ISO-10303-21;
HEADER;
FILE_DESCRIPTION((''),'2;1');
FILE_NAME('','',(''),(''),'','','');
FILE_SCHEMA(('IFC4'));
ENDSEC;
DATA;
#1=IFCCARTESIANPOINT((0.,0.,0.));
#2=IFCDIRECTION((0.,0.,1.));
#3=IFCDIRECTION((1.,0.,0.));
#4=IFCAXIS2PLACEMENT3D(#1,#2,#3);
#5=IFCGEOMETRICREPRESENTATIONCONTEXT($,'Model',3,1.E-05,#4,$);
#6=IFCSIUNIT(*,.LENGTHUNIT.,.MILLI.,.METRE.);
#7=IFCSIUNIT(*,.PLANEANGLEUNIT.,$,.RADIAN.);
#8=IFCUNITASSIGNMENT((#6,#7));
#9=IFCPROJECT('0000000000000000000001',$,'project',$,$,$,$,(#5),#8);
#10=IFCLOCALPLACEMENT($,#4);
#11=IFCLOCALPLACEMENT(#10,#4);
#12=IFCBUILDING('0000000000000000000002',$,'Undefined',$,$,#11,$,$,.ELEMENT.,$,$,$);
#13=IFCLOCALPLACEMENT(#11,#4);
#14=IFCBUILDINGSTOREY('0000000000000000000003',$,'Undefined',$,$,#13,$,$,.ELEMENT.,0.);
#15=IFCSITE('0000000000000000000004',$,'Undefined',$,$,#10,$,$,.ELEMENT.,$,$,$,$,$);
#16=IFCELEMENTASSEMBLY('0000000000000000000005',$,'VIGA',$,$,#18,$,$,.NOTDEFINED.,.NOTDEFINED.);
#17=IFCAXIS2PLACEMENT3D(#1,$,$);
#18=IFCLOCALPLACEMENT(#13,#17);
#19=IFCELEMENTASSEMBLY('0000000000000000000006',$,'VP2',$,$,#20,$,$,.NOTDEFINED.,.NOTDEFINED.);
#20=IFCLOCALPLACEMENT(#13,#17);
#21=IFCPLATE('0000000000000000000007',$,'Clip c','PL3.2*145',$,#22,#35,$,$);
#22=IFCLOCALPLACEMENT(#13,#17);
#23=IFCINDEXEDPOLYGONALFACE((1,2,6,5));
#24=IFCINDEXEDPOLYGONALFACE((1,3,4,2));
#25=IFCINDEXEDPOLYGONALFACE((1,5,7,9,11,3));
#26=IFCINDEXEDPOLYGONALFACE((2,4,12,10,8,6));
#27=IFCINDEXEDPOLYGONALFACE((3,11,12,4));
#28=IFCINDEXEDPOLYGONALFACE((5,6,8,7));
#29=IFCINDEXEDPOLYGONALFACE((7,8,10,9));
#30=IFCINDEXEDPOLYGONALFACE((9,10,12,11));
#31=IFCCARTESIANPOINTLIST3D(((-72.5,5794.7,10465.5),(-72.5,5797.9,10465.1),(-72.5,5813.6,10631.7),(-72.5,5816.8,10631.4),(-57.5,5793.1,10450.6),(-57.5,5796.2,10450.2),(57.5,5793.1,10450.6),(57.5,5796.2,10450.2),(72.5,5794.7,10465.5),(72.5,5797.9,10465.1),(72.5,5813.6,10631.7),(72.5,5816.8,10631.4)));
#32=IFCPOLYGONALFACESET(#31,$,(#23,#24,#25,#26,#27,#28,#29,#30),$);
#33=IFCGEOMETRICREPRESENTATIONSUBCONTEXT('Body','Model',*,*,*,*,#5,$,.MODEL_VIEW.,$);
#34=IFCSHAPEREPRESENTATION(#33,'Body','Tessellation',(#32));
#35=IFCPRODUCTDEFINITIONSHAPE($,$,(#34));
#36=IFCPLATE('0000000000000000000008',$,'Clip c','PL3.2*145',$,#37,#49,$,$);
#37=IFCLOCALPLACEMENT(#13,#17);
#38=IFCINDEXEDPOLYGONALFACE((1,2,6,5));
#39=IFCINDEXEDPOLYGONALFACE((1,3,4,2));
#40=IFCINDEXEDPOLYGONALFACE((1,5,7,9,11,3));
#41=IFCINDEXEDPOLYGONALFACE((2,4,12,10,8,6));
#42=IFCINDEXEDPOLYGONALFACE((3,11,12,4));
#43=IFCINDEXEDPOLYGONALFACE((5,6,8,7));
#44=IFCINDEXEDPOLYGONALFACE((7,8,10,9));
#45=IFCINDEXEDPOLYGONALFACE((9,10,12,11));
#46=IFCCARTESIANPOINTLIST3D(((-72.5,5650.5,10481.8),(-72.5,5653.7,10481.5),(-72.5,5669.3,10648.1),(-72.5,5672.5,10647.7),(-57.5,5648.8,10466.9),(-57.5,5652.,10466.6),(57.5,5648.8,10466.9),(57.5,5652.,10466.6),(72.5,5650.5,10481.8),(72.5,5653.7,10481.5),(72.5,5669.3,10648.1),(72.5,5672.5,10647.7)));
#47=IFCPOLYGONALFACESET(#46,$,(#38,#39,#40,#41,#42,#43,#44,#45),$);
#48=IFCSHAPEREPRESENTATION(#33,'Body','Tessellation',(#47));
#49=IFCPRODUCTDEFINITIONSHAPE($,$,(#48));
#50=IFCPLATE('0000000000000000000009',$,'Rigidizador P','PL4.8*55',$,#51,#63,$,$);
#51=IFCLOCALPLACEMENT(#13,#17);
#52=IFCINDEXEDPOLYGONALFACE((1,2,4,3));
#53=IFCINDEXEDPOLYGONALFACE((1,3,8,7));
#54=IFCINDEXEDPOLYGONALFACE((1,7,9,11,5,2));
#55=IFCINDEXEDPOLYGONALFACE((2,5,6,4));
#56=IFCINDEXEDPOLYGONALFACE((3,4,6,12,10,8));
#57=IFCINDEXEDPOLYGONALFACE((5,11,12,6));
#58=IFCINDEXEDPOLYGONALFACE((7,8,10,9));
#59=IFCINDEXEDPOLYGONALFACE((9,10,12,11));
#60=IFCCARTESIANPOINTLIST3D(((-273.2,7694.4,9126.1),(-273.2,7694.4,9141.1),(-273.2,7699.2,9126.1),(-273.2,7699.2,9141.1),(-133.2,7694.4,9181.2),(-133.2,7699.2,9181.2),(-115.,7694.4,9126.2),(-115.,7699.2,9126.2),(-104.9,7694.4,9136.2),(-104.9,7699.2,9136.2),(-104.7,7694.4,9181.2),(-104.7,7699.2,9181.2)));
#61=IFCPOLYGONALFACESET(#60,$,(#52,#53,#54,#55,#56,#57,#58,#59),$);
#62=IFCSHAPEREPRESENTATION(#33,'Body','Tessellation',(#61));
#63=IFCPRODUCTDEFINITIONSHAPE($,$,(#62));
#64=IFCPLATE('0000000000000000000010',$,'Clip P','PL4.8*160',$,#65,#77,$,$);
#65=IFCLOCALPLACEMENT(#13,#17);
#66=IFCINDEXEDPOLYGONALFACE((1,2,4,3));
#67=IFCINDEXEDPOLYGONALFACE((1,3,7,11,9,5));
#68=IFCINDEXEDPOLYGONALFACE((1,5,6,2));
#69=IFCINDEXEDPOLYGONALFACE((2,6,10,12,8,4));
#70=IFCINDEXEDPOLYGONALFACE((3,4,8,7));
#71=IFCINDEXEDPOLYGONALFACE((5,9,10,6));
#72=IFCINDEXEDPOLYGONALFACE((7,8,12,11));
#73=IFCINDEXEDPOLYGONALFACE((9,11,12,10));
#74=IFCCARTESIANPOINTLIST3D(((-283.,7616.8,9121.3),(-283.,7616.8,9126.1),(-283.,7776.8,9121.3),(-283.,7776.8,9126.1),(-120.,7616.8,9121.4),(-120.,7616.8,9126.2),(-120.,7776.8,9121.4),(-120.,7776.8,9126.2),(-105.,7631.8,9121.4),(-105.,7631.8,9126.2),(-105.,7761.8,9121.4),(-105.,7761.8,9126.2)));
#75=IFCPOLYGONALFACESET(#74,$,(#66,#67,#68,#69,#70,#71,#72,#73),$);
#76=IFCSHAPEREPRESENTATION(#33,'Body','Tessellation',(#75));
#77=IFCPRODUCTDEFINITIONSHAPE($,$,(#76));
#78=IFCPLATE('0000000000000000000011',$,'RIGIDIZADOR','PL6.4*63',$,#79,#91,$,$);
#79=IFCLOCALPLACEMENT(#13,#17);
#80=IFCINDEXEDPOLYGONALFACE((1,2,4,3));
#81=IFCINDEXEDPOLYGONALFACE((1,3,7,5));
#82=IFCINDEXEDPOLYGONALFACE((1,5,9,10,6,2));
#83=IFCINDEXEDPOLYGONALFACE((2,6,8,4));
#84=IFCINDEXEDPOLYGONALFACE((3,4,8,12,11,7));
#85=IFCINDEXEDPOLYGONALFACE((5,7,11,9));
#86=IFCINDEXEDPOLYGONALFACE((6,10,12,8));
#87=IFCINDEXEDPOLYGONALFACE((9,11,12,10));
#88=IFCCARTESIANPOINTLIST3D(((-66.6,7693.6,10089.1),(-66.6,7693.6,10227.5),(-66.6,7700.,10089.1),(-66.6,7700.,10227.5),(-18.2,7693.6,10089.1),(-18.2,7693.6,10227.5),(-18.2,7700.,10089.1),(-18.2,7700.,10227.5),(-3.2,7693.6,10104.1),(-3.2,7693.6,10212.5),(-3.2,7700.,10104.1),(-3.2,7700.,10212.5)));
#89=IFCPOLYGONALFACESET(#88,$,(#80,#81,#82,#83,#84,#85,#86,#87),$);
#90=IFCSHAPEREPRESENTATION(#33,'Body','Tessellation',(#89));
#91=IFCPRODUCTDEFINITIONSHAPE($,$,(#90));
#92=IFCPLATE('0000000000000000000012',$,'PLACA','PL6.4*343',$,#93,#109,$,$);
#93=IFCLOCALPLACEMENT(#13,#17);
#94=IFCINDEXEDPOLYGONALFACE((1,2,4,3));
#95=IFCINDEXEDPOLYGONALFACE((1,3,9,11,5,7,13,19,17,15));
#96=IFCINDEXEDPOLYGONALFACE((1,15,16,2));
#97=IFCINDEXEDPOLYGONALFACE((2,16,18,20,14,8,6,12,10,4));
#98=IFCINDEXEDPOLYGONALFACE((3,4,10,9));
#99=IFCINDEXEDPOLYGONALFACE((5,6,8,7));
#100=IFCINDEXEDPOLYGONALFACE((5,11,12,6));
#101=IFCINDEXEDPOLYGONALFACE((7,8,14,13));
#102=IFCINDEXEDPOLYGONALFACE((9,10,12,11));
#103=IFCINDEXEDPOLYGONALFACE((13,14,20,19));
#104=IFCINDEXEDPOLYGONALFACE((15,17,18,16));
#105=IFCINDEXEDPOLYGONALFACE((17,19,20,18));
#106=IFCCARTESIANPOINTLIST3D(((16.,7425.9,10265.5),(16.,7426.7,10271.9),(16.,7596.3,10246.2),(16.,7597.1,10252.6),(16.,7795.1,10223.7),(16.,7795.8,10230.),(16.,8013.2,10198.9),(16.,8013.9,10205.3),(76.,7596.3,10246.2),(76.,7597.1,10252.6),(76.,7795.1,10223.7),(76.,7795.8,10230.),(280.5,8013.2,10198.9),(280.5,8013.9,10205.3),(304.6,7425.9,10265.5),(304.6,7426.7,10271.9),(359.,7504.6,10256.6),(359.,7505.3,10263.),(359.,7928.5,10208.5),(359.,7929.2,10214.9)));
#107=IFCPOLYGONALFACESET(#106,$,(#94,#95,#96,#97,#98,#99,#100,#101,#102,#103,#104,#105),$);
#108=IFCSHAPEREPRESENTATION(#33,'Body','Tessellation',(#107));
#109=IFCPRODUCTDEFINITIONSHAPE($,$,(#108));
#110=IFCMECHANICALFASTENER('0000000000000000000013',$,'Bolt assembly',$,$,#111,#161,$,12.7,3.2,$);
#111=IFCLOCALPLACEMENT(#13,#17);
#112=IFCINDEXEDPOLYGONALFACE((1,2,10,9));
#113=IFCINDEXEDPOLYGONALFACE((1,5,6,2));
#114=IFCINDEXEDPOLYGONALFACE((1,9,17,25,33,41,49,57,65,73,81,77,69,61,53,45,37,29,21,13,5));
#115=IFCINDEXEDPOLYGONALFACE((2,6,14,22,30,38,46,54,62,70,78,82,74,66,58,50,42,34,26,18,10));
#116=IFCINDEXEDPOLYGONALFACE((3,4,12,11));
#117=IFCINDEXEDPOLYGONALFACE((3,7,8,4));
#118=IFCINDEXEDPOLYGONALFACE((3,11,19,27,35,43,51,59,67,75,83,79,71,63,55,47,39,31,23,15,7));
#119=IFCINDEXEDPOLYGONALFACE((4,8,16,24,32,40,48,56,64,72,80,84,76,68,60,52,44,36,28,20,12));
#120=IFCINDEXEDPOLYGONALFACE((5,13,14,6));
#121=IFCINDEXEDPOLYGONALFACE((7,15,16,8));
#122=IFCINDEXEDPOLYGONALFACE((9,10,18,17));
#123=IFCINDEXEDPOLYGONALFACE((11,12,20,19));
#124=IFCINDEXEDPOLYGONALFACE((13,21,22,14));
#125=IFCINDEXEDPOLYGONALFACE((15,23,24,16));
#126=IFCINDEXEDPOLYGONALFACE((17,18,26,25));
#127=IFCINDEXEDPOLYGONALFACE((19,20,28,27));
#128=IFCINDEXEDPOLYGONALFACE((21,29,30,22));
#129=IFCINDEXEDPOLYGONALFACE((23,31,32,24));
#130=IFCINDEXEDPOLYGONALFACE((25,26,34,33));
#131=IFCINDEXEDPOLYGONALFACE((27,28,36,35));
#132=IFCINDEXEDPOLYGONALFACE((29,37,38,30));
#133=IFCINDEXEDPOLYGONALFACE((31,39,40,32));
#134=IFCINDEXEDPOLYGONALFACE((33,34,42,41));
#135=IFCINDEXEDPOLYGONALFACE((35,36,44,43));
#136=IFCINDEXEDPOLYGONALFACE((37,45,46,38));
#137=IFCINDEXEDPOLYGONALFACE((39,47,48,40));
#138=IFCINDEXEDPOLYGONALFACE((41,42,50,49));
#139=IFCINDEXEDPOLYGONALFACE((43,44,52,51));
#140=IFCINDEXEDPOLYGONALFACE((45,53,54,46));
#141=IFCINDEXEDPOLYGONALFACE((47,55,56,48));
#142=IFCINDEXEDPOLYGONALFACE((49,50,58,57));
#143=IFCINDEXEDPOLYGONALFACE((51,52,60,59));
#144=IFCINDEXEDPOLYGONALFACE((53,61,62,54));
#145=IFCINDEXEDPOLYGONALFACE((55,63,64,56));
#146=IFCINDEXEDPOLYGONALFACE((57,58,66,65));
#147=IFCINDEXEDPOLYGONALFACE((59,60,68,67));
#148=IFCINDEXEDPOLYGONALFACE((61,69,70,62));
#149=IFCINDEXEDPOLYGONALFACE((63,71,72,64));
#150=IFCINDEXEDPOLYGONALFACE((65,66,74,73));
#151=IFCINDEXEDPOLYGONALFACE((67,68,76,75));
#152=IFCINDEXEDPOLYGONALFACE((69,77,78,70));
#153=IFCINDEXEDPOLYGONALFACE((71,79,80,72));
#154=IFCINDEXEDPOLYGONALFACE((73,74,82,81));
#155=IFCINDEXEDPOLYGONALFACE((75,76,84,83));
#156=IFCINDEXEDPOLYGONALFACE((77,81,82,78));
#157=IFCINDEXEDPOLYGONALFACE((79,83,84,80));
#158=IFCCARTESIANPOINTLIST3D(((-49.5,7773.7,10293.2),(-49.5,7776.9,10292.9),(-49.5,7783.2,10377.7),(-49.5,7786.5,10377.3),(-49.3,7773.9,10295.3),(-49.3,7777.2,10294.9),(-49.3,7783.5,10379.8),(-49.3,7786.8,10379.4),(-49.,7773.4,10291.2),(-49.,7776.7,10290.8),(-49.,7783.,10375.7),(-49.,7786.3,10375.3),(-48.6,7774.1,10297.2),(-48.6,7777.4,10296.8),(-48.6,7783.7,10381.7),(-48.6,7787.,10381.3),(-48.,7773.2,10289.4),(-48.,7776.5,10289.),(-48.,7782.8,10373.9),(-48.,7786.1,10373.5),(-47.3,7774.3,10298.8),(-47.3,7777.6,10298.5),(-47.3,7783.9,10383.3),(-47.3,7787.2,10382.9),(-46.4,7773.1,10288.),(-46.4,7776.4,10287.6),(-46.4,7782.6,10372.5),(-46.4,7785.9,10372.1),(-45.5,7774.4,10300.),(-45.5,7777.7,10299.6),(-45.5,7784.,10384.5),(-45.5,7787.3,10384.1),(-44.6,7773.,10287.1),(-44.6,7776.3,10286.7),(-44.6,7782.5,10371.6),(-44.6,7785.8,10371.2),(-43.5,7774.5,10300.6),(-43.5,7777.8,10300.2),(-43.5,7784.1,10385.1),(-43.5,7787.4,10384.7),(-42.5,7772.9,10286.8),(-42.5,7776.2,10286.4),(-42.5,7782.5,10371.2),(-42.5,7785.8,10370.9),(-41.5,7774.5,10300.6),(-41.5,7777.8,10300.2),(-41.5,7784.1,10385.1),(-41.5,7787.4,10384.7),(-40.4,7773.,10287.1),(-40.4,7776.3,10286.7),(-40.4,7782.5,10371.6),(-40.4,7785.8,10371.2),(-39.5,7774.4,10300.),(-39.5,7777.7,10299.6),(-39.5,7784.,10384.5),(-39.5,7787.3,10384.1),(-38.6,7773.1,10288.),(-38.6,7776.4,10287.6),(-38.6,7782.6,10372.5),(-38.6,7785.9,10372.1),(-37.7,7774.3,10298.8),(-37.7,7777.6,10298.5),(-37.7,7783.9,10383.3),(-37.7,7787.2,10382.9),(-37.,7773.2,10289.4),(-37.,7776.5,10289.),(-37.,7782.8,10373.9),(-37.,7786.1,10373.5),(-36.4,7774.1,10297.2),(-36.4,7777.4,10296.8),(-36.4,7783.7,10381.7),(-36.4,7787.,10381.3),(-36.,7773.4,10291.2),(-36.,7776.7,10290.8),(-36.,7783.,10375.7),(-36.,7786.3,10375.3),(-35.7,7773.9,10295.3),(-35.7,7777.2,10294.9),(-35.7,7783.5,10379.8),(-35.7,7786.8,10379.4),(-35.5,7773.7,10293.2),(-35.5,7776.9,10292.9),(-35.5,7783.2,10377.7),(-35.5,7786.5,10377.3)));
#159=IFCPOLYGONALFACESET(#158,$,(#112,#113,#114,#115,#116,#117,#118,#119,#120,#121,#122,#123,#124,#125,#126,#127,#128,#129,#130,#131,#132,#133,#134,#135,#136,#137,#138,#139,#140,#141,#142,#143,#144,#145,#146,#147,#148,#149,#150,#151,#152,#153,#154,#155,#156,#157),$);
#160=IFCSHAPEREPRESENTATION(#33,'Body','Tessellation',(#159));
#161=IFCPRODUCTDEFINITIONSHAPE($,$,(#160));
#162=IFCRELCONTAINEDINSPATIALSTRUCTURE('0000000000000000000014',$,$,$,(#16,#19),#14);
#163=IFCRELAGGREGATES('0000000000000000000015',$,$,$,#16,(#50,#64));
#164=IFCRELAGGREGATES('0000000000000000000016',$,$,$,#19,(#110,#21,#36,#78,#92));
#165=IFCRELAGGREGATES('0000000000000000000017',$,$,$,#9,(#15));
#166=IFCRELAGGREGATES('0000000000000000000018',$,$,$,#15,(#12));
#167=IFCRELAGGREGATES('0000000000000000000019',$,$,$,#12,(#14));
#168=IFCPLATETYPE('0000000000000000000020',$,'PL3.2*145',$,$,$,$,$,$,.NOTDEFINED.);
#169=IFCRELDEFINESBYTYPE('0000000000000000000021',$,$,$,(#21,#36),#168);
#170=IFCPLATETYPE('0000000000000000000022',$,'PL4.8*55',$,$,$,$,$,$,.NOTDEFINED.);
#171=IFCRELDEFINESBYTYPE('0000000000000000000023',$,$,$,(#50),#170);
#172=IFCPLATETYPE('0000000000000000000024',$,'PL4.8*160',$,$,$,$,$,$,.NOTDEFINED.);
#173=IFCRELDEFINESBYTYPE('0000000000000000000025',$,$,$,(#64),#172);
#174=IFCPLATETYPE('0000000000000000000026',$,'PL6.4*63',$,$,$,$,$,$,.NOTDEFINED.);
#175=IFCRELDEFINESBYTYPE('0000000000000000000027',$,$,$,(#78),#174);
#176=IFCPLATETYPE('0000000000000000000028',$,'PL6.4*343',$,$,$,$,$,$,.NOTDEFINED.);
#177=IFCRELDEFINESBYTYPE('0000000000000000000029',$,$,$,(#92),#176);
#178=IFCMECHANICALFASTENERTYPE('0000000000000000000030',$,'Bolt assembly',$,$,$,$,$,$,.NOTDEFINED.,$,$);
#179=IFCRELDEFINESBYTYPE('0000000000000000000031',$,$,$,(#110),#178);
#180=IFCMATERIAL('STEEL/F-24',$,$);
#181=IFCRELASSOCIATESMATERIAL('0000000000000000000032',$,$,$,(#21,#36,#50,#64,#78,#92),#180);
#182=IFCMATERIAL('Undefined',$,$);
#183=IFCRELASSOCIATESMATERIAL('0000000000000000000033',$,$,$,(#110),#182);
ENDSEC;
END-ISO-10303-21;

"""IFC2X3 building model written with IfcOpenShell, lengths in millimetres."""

from ifc_helpers import new_model, si_unit, frame, origin_with_axes, origin_2d_with_axis, place, context, subcontext, project, spatial, polyline, circle, outline, extrude, boolean, source, transform, mapped, material, type_object, element, aggregate, save


model = new_model("IFC2X3")

# Units and contexts
model_context = context("Model", 3, precision=1e-05, world=origin_with_axes())
body_context = subcontext(model_context, "Body", "Model", "MODEL_VIEW")
ifc_project = project(units=[si_unit("LENGTHUNIT", "METRE", prefix="MILLI"), si_unit("PLANEANGLEUNIT", "RADIAN")], contexts=[model_context])

# Site, building, storey
site_placement = place(None, origin_with_axes())
site = spatial("IfcSite", under=ifc_project, at=site_placement, Name="Undefined", CompositionType="ELEMENT")
building_placement = place(site_placement, origin_with_axes())
building = spatial("IfcBuilding", under=site, at=building_placement, Name="Undefined", CompositionType="ELEMENT")
storey_placement = place(building_placement, origin_with_axes())
storey = spatial("IfcBuildingStorey", under=building, at=storey_placement, Name="Undefined", CompositionType="ELEMENT", Elevation=0.0)

# Element assembly
assembly_1_placement = place(storey_placement, origin_with_axes())
assembly_1 = element("IfcElementAssembly", 1, at=assembly_1_placement, inside=storey, Name="VIGA", AssemblyPlace="NOTDEFINED", PredefinedType="NOTDEFINED")
ifc_material_1 = material(Name="STEEL/F-24")

# Element assembly, plates
assembly_2_placement = place(storey_placement, origin_with_axes())
assembly_2 = element("IfcElementAssembly", 2, at=assembly_2_placement, inside=storey, Name="VP2", AssemblyPlace="NOTDEFINED", PredefinedType="NOTDEFINED")
plate_type_1 = type_object("IfcPlateType", Name="PL3.2*145", PredefinedType="NOTDEFINED")
plate_1_placement = place(assembly_2_placement, frame((-72.5, 5794.6, 10450.4), z_axis=(0.0, 0.993626, -0.112729), x_axis=(0.0, 0.112729, 0.993626)))
plate_1 = element("IfcPlate", 3, at=plate_1_placement, type_object=plate_type_1, material=ifc_material_1, Name="Clip c", Description="PL3.2*145", context=body_context, shape_type="SweptSolid", body=[
    extrude(outline(polyline([(0.0, 15.0), (15.0, 0.0), (182.3, 0.0), (182.3, 145.0), (15.0, 145.0), (0.0, 130.0), (0.0, 15.0)])), frame((0.0, 0.0, -1.6), z_axis=(0.0, 0.0, 1.0), x_axis=(1.0, 0.0, 0.0)), (0.0, 0.0, 1.0), 3.2),
])
plate_2_placement = place(assembly_2_placement, frame((-72.5, 5650.4, 10466.7), z_axis=(0.0, 0.993645, -0.112559), x_axis=(0.0, 0.112559, 0.993645)))
plate_2 = element("IfcPlate", 4, at=plate_2_placement, type_object=plate_type_1, material=ifc_material_1, Name="Clip c", Description="PL3.2*145", context=body_context, shape_type="SweptSolid", body=[
    extrude(outline(polyline([(0.0, 15.0), (15.0, 0.0), (182.3, 0.0), (182.3, 145.0), (15.0, 145.0), (0.0, 130.0), (0.0, 15.0)])), frame((0.0, 0.0, -1.6), z_axis=(0.0, 0.0, 1.0), x_axis=(1.0, 0.0, 0.0)), (0.0, 0.0, 1.0), 3.2),
])

# Plates
plate_type_2 = type_object("IfcPlateType", Name="PL4.8*55", PredefinedType="NOTDEFINED")
plate_3_placement = place(assembly_1_placement, frame((-273.2, 7696.8, 9126.1), z_axis=(0.0, 1.0, 0.0), x_axis=(-0.000256, 0.0, 1.0)))
plate_3 = element("IfcPlate", 5, at=plate_3_placement, type_object=plate_type_2, material=ifc_material_1, Name="Rigidizador P", Description="PL4.8*55", context=body_context, shape_type="SweptSolid", body=[
    extrude(outline(polyline([(0.0, 0.0), (15.0, 0.0), (55.1, 140.0), (55.1, 168.5), (10.1, 168.2), (0.1, 158.2), (0.0, 0.0)])), frame((0.0, 0.0, -2.4), z_axis=(0.0, 0.0, 1.0), x_axis=(1.0, 0.0, 0.0)), (0.0, 0.0, 1.0), 4.8),
])
plate_type_3 = type_object("IfcPlateType", Name="PL4.8*160", PredefinedType="NOTDEFINED")
plate_4_placement = place(assembly_1_placement, frame((-105.0, 7616.8, 9123.8), z_axis=(0.000624, 0.0, -1.0), x_axis=(-1.0, 0.0, -0.000624)))
plate_4 = element("IfcPlate", 6, at=plate_4_placement, type_object=plate_type_3, material=ifc_material_1, Name="Clip P", Description="PL4.8*160", context=body_context, shape_type="SweptSolid", body=[
    extrude(outline(polyline([(0.0, 15.0), (15.0, 0.0), (178.0, 0.0), (178.0, 160.0), (15.0, 160.0), (0.0, 145.0), (0.0, 15.0)])), frame((0.0, 0.0, -2.4), z_axis=(0.0, 0.0, 1.0), x_axis=(1.0, 0.0, 0.0)), (0.0, 0.0, 1.0), 4.8),
])
aggregate(assembly_1, [plate_3, plate_4])
plate_type_4 = type_object("IfcPlateType", Name="PL6.4*63", PredefinedType="NOTDEFINED")
plate_5_placement = place(assembly_2_placement, frame((-3.2, 7696.8, 10089.1), z_axis=(0.0, 1.0, 0.0), x_axis=(-1.0, 0.0, 0.0)))
plate_5 = element("IfcPlate", 7, at=plate_5_placement, type_object=plate_type_4, material=ifc_material_1, Name="RIGIDIZADOR", Description="PL6.4*63", context=body_context, shape_type="SweptSolid", body=[
    extrude(outline(polyline([(0.0, 15.0), (15.0, 0.0), (63.4, 0.0), (63.4, 138.4), (15.0, 138.4), (0.0, 123.4), (0.0, 15.0)])), frame((0.0, 0.0, -3.2), z_axis=(0.0, 0.0, 1.0), x_axis=(1.0, 0.0, 0.0)), (0.0, 0.0, 1.0), 6.4),
])
plate_type_5 = type_object("IfcPlateType", Name="PL6.4*343", PredefinedType="NOTDEFINED")
plate_6_placement = place(assembly_2_placement, frame((16.0, 8013.6, 10202.1), z_axis=(0.000001, 0.112653, 0.993634), x_axis=(0.0, -0.993634, 0.112653)))
plate_6 = element("IfcPlate", 8, at=plate_6_placement, type_object=plate_type_5, material=ifc_material_1, Name="PLACA", Description="PL6.4*343", context=body_context, shape_type="CSG", body=[
    boolean("DIFFERENCE", extrude(outline(polyline([(0.0, 0.0), (591.0, 0.0), (591.0, 288.6), (511.9, 343.0), (85.3, 343.0), (0.0, 264.5), (0.0, 0.0)])), frame((0.0, 0.0, -3.2), z_axis=(0.0, 0.0, 1.0), x_axis=(1.0, 0.0, 0.0)), (0.0, 0.0, 1.0), 6.4), extrude(outline(polyline([(0.0, 0.0), (60.0, 0.0), (60.0, 200.0), (0.0, 200.0), (0.0, 0.0)])), frame((219.6, 0.0, 5.2), z_axis=(-0.000104, 0.000001, -1.0), x_axis=(0.0, 1.0, 0.0)), (0.0, 0.0, 1.0), 12.0)),
])

# Mechanical fastener
ifc_material_2 = material(Name="Undefined")
mechanical_fastener_type = type_object("IfcMechanicalFastenerType", Name="Bolt assembly")
shared_shape_1 = source(origin_with_axes(), body_context, "Body", "SweptSolid", [
    extrude(circle(Radius=7.0, at=origin_2d_with_axis()), frame((0.0, -3.2, 0.0), z_axis=(0.0, 1.0, 0.0), x_axis=(1.0, 0.0, 0.0)), (0.0, 0.0, 1.0), 3.3),
])
mechanical_fastener_1_placement = place(assembly_2_placement, frame((-42.5, 7783.4, 10378.2), z_axis=(-1.0, 0.0, 0.0), x_axis=(0.0, -0.112644, -0.993635)))
mechanical_fastener_1 = element("IfcMechanicalFastener", 9, at=mechanical_fastener_1_placement, type_object=mechanical_fastener_type, material=ifc_material_2, Name="Bolt assembly", NominalDiameter=12.7, NominalLength=3.2, context=body_context, shape_type="MappedRepresentation", body=[
    mapped(shared_shape_1, transform((0.0, 0.0, 0.0))),
    mapped(shared_shape_1, transform((85.0, 0.0, 0.0))),
])

aggregate(assembly_2, [mechanical_fastener_1, plate_1, plate_2, plate_5, plate_6])

save(model, "model.ifc")
